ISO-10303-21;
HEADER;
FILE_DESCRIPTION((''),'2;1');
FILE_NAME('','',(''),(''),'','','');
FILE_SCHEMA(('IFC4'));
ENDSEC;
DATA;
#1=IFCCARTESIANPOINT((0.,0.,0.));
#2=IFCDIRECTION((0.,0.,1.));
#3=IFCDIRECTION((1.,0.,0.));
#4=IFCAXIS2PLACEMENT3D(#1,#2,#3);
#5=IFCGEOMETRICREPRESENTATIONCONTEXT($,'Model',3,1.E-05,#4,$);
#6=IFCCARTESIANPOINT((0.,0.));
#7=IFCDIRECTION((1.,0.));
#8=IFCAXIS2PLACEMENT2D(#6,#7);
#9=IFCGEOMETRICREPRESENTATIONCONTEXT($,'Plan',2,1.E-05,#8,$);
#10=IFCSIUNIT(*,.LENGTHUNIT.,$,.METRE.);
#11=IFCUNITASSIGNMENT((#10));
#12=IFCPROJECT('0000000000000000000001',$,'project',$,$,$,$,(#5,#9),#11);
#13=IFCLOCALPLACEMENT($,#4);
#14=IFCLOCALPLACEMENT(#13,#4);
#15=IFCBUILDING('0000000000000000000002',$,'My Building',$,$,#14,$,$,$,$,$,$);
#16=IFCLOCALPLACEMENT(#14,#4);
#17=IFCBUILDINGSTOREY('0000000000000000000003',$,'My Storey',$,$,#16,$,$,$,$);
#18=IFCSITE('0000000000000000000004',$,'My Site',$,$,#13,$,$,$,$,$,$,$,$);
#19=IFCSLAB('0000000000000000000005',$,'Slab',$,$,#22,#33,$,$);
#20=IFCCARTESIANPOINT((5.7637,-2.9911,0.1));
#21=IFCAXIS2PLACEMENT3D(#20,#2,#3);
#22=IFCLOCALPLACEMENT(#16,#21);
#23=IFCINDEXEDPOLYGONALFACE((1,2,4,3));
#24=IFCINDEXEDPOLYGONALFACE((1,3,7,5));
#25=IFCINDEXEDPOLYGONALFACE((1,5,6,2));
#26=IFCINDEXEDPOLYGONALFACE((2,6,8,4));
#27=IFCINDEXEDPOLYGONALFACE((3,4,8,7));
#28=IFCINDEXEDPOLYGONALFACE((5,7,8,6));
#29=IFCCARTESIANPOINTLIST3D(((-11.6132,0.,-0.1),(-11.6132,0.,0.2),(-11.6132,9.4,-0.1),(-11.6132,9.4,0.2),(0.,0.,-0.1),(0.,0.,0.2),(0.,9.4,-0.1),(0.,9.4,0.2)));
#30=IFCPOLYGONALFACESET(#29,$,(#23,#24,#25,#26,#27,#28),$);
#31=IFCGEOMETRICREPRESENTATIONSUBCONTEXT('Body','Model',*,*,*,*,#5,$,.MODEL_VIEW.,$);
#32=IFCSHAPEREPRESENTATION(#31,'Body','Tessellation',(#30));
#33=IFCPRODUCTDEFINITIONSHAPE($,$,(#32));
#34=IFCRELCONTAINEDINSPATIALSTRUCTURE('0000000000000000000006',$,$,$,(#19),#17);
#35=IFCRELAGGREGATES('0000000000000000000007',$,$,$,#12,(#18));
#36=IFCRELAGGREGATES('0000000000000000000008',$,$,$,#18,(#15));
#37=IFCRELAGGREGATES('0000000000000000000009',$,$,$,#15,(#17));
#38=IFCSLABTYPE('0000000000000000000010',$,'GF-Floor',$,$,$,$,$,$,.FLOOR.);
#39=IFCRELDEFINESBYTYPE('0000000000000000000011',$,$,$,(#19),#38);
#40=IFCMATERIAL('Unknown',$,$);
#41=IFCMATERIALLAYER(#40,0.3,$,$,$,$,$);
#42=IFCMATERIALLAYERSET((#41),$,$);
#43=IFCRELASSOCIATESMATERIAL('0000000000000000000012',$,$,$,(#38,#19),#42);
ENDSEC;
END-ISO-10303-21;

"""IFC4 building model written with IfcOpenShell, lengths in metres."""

from ifc_helpers import new_model, si_unit, frame, origin_with_axes, origin_2d_with_axis, place, context, subcontext, project, spatial, indexed_curve, outline, extrude, material, layer, layer_set, layer_usage, type_object, element, save


model = new_model("IFC4")

# Units and contexts
model_context = context("Model", 3, precision=1e-05, world=origin_with_axes())
plan_context = context("Plan", 2, precision=1e-05, world=origin_2d_with_axis())
body_context = subcontext(model_context, "Body", "Model", "MODEL_VIEW")
ifc_project = project(units=[si_unit("LENGTHUNIT", "METRE")], contexts=[model_context, plan_context])

# Site, building, storey
site_placement = place(None, origin_with_axes())
site = spatial("IfcSite", under=ifc_project, at=site_placement, Name="My Site")
building_placement = place(site_placement, origin_with_axes())
building = spatial("IfcBuilding", under=site, at=building_placement, Name="My Building")
storey_placement = place(building_placement, origin_with_axes())
storey = spatial("IfcBuildingStorey", under=building, at=storey_placement, Name="My Storey")

# Slab
ifc_material = material(Name="Unknown")
ifc_layer_1 = layer(ifc_material, 0.3)
ifc_layer_set_1 = layer_set([ifc_layer_1])
ifc_layer_usage_1 = layer_usage(ifc_layer_set_1, "AXIS3", "POSITIVE", -0.1)
slab_type_1 = type_object("IfcSlabType", Name="GF-Floor", PredefinedType="FLOOR", material=ifc_layer_set_1)
slab_1_placement = place(storey_placement, frame((5.7637, -2.9911, 0.1), z_axis=(0.0, 0.0, 1.0), x_axis=(1.0, 0.0, 0.0)))
element("IfcSlab", 1, at=slab_1_placement, inside=storey, type_object=slab_type_1, material=ifc_layer_usage_1, Name="Slab", context=body_context, shape_type="SweptSolid", body=[
    extrude(outline(indexed_curve([(0.0, 0.0), (-11.6132, 0.0), (-11.6132, 9.4), (0.0, 9.4), (0.0, 0.0)])), frame((0.0, 0.0, -0.1), z_axis=(0.0, 0.0, 1.0), x_axis=(1.0, 0.0, 0.0)), (0.0, 0.0, 1.0), 0.3),
])

save(model, "model.ifc")
